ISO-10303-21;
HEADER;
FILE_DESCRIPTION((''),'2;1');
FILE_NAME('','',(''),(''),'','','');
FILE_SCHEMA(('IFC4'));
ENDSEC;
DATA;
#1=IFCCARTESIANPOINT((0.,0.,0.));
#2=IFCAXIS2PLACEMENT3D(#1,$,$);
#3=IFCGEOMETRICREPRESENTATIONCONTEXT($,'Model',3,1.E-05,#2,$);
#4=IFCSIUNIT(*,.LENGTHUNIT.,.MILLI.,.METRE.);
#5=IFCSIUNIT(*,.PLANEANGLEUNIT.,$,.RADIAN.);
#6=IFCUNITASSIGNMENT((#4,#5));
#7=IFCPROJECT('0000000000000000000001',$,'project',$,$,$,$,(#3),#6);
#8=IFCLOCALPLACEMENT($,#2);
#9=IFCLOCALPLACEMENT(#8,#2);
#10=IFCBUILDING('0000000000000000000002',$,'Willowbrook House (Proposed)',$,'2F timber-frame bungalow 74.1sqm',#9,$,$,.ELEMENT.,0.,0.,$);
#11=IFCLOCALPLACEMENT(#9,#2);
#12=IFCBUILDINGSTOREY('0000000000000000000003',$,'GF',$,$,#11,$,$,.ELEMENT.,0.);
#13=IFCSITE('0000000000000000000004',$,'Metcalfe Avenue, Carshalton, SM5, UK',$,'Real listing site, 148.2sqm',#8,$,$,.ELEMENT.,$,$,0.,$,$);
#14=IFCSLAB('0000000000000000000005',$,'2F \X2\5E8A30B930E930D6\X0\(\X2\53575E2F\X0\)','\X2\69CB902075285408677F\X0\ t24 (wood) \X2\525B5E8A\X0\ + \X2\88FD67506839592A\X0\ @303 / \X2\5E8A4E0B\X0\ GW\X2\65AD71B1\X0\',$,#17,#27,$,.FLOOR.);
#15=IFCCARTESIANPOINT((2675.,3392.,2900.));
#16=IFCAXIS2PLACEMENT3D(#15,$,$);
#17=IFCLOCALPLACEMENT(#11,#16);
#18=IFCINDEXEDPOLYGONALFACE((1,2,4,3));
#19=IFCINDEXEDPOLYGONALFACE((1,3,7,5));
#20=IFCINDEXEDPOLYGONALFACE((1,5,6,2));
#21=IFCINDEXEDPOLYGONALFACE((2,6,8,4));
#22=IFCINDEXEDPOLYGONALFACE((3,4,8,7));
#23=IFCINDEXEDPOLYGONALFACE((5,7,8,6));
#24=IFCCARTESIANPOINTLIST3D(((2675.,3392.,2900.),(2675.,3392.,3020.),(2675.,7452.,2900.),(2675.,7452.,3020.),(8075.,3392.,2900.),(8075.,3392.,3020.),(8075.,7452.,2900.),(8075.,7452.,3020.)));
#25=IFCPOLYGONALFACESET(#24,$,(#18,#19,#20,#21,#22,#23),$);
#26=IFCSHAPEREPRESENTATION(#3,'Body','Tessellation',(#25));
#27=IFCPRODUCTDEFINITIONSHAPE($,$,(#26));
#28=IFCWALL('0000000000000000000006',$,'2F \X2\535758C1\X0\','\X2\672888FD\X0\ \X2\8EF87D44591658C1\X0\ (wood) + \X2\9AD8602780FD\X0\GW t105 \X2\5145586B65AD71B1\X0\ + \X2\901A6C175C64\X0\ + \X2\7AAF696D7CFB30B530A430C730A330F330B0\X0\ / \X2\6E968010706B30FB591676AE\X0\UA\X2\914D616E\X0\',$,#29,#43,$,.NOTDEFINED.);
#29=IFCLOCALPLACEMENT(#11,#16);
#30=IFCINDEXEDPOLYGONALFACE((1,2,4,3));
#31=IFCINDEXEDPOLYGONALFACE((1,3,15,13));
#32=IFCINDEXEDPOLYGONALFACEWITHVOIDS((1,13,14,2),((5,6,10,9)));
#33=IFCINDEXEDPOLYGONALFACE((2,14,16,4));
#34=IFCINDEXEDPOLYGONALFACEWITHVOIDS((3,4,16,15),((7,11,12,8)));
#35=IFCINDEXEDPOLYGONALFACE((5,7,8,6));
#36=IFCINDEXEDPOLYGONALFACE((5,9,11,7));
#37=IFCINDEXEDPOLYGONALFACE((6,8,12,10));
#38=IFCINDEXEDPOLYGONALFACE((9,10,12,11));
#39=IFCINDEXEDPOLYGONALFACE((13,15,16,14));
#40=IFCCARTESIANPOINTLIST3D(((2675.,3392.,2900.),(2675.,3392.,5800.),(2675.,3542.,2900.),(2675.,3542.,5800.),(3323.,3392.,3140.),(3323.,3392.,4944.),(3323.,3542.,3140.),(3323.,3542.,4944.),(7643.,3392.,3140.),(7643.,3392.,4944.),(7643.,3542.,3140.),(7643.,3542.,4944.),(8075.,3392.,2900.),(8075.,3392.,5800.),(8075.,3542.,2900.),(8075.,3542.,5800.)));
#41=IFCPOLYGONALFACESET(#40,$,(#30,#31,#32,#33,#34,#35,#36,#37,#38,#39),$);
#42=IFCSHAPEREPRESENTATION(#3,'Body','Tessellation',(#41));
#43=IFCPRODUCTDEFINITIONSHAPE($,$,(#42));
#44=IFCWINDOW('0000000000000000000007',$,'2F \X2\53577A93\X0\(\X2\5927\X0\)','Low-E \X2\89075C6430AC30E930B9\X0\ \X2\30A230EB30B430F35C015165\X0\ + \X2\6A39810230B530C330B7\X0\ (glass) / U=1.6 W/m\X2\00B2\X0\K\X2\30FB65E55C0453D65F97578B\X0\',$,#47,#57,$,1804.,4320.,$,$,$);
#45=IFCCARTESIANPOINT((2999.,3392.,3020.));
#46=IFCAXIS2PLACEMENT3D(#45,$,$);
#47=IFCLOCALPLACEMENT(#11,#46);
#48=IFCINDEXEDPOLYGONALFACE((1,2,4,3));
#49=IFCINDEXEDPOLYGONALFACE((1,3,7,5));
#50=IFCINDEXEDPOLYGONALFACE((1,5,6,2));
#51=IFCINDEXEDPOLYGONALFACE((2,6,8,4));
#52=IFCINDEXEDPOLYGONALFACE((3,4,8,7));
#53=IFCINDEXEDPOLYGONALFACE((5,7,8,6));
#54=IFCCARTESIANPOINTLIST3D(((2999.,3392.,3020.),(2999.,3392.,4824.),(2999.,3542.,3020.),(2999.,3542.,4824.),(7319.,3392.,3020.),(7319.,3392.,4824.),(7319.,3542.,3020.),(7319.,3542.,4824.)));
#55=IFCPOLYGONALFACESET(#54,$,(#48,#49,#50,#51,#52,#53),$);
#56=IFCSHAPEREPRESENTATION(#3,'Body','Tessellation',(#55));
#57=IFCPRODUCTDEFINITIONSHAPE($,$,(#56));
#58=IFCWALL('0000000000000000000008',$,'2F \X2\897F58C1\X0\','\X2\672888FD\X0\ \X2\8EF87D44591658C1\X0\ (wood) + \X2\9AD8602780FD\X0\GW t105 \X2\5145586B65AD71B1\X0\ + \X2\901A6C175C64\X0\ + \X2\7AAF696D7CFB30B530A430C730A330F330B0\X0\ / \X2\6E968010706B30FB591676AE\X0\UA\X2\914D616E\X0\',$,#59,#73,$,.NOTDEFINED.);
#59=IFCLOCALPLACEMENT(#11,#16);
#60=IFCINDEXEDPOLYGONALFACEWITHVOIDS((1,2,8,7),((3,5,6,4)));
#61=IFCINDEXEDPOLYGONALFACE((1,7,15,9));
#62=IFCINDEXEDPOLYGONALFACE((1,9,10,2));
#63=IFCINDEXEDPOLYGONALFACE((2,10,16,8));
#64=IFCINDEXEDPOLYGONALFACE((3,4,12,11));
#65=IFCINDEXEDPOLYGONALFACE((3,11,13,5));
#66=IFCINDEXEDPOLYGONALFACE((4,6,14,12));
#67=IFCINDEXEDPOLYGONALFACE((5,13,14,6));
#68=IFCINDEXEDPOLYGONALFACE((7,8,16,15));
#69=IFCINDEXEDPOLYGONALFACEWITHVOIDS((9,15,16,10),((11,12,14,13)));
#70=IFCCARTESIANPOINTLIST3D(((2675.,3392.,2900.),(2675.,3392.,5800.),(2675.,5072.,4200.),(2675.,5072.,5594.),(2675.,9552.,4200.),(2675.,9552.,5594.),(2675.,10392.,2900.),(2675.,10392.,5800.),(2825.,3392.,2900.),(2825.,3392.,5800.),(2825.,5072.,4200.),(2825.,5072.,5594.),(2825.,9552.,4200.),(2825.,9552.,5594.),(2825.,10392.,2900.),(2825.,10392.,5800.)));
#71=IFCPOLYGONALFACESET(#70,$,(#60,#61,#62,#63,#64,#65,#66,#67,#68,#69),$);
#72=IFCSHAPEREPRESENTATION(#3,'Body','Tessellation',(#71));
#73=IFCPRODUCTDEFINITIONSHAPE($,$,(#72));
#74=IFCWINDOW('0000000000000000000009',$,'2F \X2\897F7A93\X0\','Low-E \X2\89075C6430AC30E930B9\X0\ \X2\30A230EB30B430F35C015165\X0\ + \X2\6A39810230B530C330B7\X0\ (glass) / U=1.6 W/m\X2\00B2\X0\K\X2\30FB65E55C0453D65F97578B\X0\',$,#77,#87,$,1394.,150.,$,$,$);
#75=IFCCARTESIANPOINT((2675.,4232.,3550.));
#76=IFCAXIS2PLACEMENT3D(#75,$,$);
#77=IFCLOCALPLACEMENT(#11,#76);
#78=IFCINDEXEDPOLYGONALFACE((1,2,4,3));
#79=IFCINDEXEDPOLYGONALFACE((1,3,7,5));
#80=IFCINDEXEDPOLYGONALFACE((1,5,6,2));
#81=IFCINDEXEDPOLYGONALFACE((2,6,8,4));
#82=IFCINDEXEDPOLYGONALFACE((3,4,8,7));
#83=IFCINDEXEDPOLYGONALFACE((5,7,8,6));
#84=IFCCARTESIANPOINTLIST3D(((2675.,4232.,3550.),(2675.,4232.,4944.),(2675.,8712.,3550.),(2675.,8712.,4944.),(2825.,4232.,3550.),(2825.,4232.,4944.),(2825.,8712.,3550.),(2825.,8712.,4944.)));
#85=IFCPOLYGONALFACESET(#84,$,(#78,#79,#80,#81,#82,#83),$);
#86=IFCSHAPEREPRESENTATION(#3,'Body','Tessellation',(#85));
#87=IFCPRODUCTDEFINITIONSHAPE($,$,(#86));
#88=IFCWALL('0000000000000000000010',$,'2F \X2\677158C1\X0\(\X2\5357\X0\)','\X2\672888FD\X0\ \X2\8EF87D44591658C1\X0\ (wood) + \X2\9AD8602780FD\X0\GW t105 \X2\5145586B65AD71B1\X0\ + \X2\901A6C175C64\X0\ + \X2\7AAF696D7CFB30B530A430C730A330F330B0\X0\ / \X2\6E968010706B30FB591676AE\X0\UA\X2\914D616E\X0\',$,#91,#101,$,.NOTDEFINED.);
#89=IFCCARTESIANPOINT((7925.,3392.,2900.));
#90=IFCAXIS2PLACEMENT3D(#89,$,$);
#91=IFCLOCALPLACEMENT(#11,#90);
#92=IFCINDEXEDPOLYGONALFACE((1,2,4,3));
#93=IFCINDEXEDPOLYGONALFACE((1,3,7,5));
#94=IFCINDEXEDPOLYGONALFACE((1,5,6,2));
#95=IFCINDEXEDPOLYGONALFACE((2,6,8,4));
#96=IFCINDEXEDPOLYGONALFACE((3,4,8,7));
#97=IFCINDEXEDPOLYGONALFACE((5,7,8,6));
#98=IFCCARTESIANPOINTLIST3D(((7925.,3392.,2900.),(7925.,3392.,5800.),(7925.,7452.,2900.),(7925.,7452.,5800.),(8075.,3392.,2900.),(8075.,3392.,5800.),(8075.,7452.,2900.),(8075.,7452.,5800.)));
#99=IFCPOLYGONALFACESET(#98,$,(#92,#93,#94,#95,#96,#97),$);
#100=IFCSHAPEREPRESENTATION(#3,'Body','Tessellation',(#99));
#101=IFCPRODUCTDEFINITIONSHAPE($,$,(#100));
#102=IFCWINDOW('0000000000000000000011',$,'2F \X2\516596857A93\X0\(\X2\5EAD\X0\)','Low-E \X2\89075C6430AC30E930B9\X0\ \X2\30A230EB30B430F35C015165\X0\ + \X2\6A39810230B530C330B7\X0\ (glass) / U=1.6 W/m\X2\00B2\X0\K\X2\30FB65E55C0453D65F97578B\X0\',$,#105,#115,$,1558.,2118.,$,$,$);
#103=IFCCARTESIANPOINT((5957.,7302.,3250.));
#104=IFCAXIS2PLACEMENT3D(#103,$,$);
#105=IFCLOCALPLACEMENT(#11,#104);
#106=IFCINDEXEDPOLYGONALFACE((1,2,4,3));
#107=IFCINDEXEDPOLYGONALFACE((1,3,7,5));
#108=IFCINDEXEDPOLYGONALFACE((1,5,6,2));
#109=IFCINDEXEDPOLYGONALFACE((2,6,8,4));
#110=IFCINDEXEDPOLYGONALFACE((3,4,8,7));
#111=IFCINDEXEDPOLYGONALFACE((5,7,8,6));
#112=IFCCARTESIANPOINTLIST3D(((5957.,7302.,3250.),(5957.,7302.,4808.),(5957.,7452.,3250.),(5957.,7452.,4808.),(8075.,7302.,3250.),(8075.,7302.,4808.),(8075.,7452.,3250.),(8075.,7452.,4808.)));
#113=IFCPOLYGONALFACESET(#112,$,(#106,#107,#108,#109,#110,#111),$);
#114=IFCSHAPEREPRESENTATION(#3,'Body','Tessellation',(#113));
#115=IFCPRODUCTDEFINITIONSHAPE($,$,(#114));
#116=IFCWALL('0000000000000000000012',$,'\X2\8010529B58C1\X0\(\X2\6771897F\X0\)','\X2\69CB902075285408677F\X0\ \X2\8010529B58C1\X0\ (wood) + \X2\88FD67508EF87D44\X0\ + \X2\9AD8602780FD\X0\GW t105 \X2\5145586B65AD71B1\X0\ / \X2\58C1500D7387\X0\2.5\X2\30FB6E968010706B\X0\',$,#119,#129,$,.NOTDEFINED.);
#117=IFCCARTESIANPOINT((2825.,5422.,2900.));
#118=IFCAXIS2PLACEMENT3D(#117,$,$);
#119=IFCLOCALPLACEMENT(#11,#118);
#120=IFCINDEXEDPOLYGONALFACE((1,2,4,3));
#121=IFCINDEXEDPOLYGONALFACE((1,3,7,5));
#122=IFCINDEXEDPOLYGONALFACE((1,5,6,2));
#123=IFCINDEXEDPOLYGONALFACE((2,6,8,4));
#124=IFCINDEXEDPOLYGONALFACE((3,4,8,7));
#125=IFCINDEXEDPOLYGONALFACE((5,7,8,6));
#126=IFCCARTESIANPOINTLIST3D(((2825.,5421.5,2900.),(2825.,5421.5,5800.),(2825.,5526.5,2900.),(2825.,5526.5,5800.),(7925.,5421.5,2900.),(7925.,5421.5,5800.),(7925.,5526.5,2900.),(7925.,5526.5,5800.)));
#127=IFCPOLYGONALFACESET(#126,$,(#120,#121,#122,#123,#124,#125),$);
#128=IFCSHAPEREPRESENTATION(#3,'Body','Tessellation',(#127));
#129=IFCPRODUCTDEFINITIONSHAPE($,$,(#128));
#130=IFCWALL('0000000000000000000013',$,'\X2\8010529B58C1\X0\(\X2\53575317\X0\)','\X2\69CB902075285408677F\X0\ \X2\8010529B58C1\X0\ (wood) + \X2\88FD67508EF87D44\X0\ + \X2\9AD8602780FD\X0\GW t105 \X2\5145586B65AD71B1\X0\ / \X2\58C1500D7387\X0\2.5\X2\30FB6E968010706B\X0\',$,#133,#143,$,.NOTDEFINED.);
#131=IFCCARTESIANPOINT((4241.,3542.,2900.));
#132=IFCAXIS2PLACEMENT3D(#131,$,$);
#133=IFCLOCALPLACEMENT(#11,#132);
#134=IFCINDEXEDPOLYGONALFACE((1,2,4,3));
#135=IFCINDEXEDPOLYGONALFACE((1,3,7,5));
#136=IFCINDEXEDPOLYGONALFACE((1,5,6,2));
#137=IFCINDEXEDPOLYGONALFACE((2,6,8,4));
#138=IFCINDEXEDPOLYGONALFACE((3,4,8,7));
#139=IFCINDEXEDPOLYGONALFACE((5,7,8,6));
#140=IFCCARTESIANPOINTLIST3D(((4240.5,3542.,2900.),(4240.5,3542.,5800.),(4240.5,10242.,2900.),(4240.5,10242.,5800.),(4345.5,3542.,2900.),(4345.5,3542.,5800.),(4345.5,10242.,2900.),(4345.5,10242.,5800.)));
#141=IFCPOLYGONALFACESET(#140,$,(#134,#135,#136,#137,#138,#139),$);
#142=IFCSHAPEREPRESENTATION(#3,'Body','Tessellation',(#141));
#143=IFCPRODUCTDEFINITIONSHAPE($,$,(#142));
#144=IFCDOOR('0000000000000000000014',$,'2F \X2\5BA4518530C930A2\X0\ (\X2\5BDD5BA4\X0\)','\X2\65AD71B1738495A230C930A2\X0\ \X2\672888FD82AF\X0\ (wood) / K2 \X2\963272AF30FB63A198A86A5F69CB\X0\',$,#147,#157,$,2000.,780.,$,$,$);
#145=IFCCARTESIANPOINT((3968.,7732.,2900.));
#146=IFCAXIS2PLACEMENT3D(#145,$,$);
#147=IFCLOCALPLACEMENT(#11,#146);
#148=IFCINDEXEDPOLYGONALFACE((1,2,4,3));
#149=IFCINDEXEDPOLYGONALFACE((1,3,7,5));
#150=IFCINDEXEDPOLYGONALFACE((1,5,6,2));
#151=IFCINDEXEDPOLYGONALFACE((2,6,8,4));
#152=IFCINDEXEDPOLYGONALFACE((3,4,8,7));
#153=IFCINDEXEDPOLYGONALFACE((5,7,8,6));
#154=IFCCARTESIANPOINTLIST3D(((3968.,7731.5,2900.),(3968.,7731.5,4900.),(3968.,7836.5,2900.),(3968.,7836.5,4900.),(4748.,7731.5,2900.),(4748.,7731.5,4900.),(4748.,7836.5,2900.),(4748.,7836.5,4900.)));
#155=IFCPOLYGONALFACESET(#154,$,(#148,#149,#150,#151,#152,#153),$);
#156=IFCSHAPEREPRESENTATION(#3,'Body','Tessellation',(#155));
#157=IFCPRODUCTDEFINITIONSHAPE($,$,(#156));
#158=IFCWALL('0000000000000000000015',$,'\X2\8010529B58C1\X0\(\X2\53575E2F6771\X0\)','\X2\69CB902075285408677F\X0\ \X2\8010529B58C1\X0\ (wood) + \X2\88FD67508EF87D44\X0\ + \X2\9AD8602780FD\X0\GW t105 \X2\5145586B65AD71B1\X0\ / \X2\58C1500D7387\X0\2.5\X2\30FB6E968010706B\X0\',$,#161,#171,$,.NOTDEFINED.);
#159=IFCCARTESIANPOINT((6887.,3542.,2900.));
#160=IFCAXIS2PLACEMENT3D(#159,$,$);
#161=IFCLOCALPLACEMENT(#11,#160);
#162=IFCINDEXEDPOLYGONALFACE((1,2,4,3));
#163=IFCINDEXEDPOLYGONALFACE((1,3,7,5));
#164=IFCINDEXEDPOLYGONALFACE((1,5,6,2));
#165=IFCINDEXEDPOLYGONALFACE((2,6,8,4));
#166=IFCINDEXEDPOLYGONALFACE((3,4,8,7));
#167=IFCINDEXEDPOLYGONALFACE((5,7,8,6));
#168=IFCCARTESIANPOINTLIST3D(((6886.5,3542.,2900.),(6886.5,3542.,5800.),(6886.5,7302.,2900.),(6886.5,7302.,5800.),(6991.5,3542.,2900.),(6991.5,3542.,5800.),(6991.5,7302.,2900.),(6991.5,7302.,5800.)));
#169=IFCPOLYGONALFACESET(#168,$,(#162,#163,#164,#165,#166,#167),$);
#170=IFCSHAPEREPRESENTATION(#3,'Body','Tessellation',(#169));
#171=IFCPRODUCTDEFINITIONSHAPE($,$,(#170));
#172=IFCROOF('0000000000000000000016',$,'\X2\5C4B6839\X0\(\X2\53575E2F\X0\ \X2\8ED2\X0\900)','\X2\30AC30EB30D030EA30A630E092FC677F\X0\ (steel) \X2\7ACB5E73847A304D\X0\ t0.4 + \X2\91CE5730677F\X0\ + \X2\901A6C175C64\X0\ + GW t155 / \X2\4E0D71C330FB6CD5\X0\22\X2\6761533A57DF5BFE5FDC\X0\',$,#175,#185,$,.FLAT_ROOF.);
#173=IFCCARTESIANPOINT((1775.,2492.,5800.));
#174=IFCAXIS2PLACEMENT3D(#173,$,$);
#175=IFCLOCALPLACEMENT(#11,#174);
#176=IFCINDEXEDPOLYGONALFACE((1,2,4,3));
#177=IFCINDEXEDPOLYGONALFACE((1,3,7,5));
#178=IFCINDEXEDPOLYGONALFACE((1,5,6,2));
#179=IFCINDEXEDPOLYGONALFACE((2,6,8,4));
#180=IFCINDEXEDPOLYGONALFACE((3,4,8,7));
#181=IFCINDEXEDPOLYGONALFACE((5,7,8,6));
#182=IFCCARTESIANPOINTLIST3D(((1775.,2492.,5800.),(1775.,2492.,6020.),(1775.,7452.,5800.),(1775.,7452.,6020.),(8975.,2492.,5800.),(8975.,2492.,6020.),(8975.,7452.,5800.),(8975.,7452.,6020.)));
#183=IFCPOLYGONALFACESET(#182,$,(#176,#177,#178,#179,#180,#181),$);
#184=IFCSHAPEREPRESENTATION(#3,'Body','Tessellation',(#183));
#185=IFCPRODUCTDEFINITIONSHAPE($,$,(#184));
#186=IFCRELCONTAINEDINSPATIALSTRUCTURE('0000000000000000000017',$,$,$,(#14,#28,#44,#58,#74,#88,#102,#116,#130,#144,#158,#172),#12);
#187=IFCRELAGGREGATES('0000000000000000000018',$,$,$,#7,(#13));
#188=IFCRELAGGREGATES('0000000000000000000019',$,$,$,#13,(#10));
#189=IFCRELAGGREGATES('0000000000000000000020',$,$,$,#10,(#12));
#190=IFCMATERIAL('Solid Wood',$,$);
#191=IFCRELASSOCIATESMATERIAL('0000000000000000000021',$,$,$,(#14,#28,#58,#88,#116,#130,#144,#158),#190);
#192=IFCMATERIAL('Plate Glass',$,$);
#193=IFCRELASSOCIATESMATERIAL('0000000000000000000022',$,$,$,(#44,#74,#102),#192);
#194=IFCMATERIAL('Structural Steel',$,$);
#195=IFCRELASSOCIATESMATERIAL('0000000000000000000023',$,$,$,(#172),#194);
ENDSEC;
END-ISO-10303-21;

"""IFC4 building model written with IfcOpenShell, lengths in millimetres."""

from ifc_helpers import new_model, si_unit, frame, frame_2d, origin, place, context, project, spatial, rectangle, extrude, material, element, fill, save


model = new_model("IFC4")

# Units and contexts
model_context = context("Model", 3, precision=1e-05, world=origin())
ifc_project = project(units=[si_unit("LENGTHUNIT", "METRE", prefix="MILLI"), si_unit("PLANEANGLEUNIT", "RADIAN")], contexts=[model_context])

# Site, building, storey
site_placement = place(None, origin())
site = spatial("IfcSite", under=ifc_project, at=site_placement, Name="Metcalfe Avenue, Carshalton, SM5, UK", ObjectType="Real listing site, 148.2sqm", CompositionType="ELEMENT", RefElevation=0.0)
building_placement = place(site_placement, origin())
building = spatial("IfcBuilding", under=site, at=building_placement, Name="Willowbrook House (Proposed)", ObjectType="2F timber-frame bungalow 74.1sqm", CompositionType="ELEMENT", ElevationOfRefHeight=0.0, ElevationOfTerrain=0.0)
storey_placement = place(building_placement, origin())
storey = spatial("IfcBuildingStorey", under=building, at=storey_placement, Name="GF", CompositionType="ELEMENT", Elevation=0.0)

# Slab
ifc_material_1 = material(Name="Solid Wood")
slab_placement = place(storey_placement, frame((2675.0, 3392.0, 2900.0)))
element("IfcSlab", 1, at=slab_placement, inside=storey, material=ifc_material_1, Name="2F 床スラブ(南帯)", Description="構造用合板 t24 (wood) 剛床 + 製材根太 @303 / 床下 GW断熱", PredefinedType="FLOOR", context=model_context, shape_type="SweptSolid", body=[
    extrude(rectangle(XDim=5400.0, YDim=4060.0, at=frame_2d((2700.0, 2030.0))), frame((2675.0, 3392.0, 2900.0)), (0.0, 0.0, 1.0), 120.0),
])

# Walls, openings, windows
wall_1_placement = place(storey_placement, frame((2675.0, 3392.0, 2900.0)))
wall_1 = element("IfcWall", 2, at=wall_1_placement, inside=storey, material=ifc_material_1, Name="2F 南壁", Description="木製 軸組外壁 (wood) + 高性能GW t105 充填断熱 + 通気層 + 窯業系サイディング / 準耐火・外皮UA配慮", PredefinedType="NOTDEFINED", context=model_context, shape_type="SweptSolid", body=[
    extrude(rectangle(XDim=5400.0, YDim=150.0, at=frame_2d((2700.0, 75.0))), frame((2675.0, 3392.0, 2900.0)), (0.0, 0.0, 1.0), 2900.0),
])
opening_1_placement = place(storey_placement, frame((2999.0, 3392.0, 3020.0)))
opening_1 = element("IfcOpeningElement", 3, at=opening_1_placement, cuts=wall_1, PredefinedType="NOTDEFINED", context=model_context, shape_type="SweptSolid", body=[
    extrude(rectangle(XDim=4320.0, YDim=150.0, at=frame_2d((2160.0, 75.0))), frame((2999.0, 3392.0, 3020.0)), (0.0, 0.0, 1.0), 1804.0),
])
ifc_material_2 = material(Name="Plate Glass")
window_1_placement = place(storey_placement, frame((2999.0, 3392.0, 3020.0)))
window_1 = element("IfcWindow", 4, at=window_1_placement, inside=storey, material=ifc_material_2, Name="2F 南窓(大)", Description="Low-E 複層ガラス アルゴン封入 + 樹脂サッシ (glass) / U=1.6 W/m²K・日射取得型", OverallHeight=1804.0, OverallWidth=4320.0, context=model_context, shape_type="SweptSolid", body=[
    extrude(rectangle(XDim=4320.0, YDim=150.0, at=frame_2d((2160.0, 75.0))), frame((2999.0, 3392.0, 3020.0)), (0.0, 0.0, 1.0), 1804.0),
])
fill(opening_1, window_1)
wall_2_placement = place(storey_placement, frame((2675.0, 3392.0, 2900.0)))
wall_2 = element("IfcWall", 5, at=wall_2_placement, inside=storey, material=ifc_material_1, Name="2F 西壁", Description="木製 軸組外壁 (wood) + 高性能GW t105 充填断熱 + 通気層 + 窯業系サイディング / 準耐火・外皮UA配慮", PredefinedType="NOTDEFINED", context=model_context, shape_type="SweptSolid", body=[
    extrude(rectangle(XDim=150.0, YDim=7000.0, at=frame_2d((75.0, 3500.0))), frame((2675.0, 3392.0, 2900.0)), (0.0, 0.0, 1.0), 2900.0),
])
opening_2_placement = place(storey_placement, frame((2675.0, 4232.0, 3550.0)))
opening_2 = element("IfcOpeningElement", 6, at=opening_2_placement, cuts=wall_2, PredefinedType="NOTDEFINED", context=model_context, shape_type="SweptSolid", body=[
    extrude(rectangle(XDim=150.0, YDim=4480.0, at=frame_2d((75.0, 2240.0))), frame((2675.0, 4232.0, 3550.0)), (0.0, 0.0, 1.0), 1394.0),
])
window_2_placement = place(storey_placement, frame((2675.0, 4232.0, 3550.0)))
window_2 = element("IfcWindow", 7, at=window_2_placement, inside=storey, material=ifc_material_2, Name="2F 西窓", Description="Low-E 複層ガラス アルゴン封入 + 樹脂サッシ (glass) / U=1.6 W/m²K・日射取得型", OverallHeight=1394.0, OverallWidth=150.0, context=model_context, shape_type="SweptSolid", body=[
    extrude(rectangle(XDim=150.0, YDim=4480.0, at=frame_2d((75.0, 2240.0))), frame((2675.0, 4232.0, 3550.0)), (0.0, 0.0, 1.0), 1394.0),
])
fill(opening_2, window_2)
wall_3_placement = place(storey_placement, frame((7925.0, 3392.0, 2900.0)))
wall_3 = element("IfcWall", 8, at=wall_3_placement, inside=storey, material=ifc_material_1, Name="2F 東壁(南)", Description="木製 軸組外壁 (wood) + 高性能GW t105 充填断熱 + 通気層 + 窯業系サイディング / 準耐火・外皮UA配慮", PredefinedType="NOTDEFINED", context=model_context, shape_type="SweptSolid", body=[
    extrude(rectangle(XDim=150.0, YDim=4060.0, at=frame_2d((75.0, 2030.0))), frame((7925.0, 3392.0, 2900.0)), (0.0, 0.0, 1.0), 2900.0),
])
opening_3_placement = place(storey_placement, frame((5957.0, 7302.0, 3250.0)))
opening_3 = element("IfcOpeningElement", 9, at=opening_3_placement, cuts=wall_3, PredefinedType="NOTDEFINED", context=model_context, shape_type="SweptSolid", body=[
    extrude(rectangle(XDim=2118.0, YDim=150.0, at=frame_2d((1059.0, 75.0))), frame((5957.0, 7302.0, 3250.0)), (0.0, 0.0, 1.0), 1558.0),
])
window_3_placement = place(storey_placement, frame((5957.0, 7302.0, 3250.0)))
window_3 = element("IfcWindow", 10, at=window_3_placement, inside=storey, material=ifc_material_2, Name="2F 入隅窓(庭)", Description="Low-E 複層ガラス アルゴン封入 + 樹脂サッシ (glass) / U=1.6 W/m²K・日射取得型", OverallHeight=1558.0, OverallWidth=2118.0, context=model_context, shape_type="SweptSolid", body=[
    extrude(rectangle(XDim=2118.0, YDim=150.0, at=frame_2d((1059.0, 75.0))), frame((5957.0, 7302.0, 3250.0)), (0.0, 0.0, 1.0), 1558.0),
])
fill(opening_3, window_3)

# Wall
wall_4_placement = place(storey_placement, frame((2825.0, 5422.0, 2900.0)))
element("IfcWall", 11, at=wall_4_placement, inside=storey, material=ifc_material_1, Name="耐力壁(東西)", Description="構造用合板 耐力壁 (wood) + 製材軸組 + 高性能GW t105 充填断熱 / 壁倍率2.5・準耐火", PredefinedType="NOTDEFINED", context=model_context, shape_type="SweptSolid", body=[
    extrude(rectangle(XDim=5100.0, YDim=105.0, at=frame_2d((2550.0, 52.0))), frame((2825.0, 5422.0, 2900.0)), (0.0, 0.0, 1.0), 2900.0),
])

# Wall, opening, door
wall_5_placement = place(storey_placement, frame((4241.0, 3542.0, 2900.0)))
wall_5 = element("IfcWall", 12, at=wall_5_placement, inside=storey, material=ifc_material_1, Name="耐力壁(南北)", Description="構造用合板 耐力壁 (wood) + 製材軸組 + 高性能GW t105 充填断熱 / 壁倍率2.5・準耐火", PredefinedType="NOTDEFINED", context=model_context, shape_type="SweptSolid", body=[
    extrude(rectangle(XDim=105.0, YDim=6700.0, at=frame_2d((52.0, 3350.0))), frame((4241.0, 3542.0, 2900.0)), (0.0, 0.0, 1.0), 2900.0),
])
opening_4_placement = place(storey_placement, frame((3968.0, 7732.0, 2900.0)))
opening_4 = element("IfcOpeningElement", 13, at=opening_4_placement, cuts=wall_5, PredefinedType="NOTDEFINED", context=model_context, shape_type="SweptSolid", body=[
    extrude(rectangle(XDim=780.0, YDim=105.0, at=frame_2d((390.0, 52.0))), frame((3968.0, 7732.0, 2900.0)), (0.0, 0.0, 1.0), 2000.0),
])
door_placement = place(storey_placement, frame((3968.0, 7732.0, 2900.0)))
door = element("IfcDoor", 14, at=door_placement, inside=storey, material=ifc_material_1, Name="2F 室内ドア (寝室)", Description="断熱玄関ドア 木製芯 (wood) / K2 防犯・採風機構", OverallHeight=2000.0, OverallWidth=780.0, context=model_context, shape_type="SweptSolid", body=[
    extrude(rectangle(XDim=780.0, YDim=105.0, at=frame_2d((390.0, 52.0))), frame((3968.0, 7732.0, 2900.0)), (0.0, 0.0, 1.0), 2000.0),
])
fill(opening_4, door)

# Wall
wall_6_placement = place(storey_placement, frame((6887.0, 3542.0, 2900.0)))
element("IfcWall", 15, at=wall_6_placement, inside=storey, material=ifc_material_1, Name="耐力壁(南帯東)", Description="構造用合板 耐力壁 (wood) + 製材軸組 + 高性能GW t105 充填断熱 / 壁倍率2.5・準耐火", PredefinedType="NOTDEFINED", context=model_context, shape_type="SweptSolid", body=[
    extrude(rectangle(XDim=105.0, YDim=3760.0, at=frame_2d((52.0, 1880.0))), frame((6887.0, 3542.0, 2900.0)), (0.0, 0.0, 1.0), 2900.0),
])

# Roof
ifc_material_3 = material(Name="Structural Steel")
for number, where, name in (
    (16, (1775.0, 2492.0, 5800.0), "屋根(南帯 軒900)"),
):
    element("IfcRoof", number, at=place(storey_placement, frame(where)), inside=storey, material=ifc_material_3, Name=name, Description="ガルバリウム鋼板 (steel) 立平葺き t0.4 + 野地板 + 通気層 + GW t155 / 不燃・法22条区域対応", PredefinedType="FLAT_ROOF", context=model_context, shape_type="SweptSolid", body=[
        extrude(rectangle(XDim=7200.0, YDim=4960.0, at=frame_2d((3600.0, 2480.0))), frame((1775.0, 2492.0, 5800.0)), (0.0, 0.0, 1.0), 220.0),
    ])

save(model, "model.ifc")
